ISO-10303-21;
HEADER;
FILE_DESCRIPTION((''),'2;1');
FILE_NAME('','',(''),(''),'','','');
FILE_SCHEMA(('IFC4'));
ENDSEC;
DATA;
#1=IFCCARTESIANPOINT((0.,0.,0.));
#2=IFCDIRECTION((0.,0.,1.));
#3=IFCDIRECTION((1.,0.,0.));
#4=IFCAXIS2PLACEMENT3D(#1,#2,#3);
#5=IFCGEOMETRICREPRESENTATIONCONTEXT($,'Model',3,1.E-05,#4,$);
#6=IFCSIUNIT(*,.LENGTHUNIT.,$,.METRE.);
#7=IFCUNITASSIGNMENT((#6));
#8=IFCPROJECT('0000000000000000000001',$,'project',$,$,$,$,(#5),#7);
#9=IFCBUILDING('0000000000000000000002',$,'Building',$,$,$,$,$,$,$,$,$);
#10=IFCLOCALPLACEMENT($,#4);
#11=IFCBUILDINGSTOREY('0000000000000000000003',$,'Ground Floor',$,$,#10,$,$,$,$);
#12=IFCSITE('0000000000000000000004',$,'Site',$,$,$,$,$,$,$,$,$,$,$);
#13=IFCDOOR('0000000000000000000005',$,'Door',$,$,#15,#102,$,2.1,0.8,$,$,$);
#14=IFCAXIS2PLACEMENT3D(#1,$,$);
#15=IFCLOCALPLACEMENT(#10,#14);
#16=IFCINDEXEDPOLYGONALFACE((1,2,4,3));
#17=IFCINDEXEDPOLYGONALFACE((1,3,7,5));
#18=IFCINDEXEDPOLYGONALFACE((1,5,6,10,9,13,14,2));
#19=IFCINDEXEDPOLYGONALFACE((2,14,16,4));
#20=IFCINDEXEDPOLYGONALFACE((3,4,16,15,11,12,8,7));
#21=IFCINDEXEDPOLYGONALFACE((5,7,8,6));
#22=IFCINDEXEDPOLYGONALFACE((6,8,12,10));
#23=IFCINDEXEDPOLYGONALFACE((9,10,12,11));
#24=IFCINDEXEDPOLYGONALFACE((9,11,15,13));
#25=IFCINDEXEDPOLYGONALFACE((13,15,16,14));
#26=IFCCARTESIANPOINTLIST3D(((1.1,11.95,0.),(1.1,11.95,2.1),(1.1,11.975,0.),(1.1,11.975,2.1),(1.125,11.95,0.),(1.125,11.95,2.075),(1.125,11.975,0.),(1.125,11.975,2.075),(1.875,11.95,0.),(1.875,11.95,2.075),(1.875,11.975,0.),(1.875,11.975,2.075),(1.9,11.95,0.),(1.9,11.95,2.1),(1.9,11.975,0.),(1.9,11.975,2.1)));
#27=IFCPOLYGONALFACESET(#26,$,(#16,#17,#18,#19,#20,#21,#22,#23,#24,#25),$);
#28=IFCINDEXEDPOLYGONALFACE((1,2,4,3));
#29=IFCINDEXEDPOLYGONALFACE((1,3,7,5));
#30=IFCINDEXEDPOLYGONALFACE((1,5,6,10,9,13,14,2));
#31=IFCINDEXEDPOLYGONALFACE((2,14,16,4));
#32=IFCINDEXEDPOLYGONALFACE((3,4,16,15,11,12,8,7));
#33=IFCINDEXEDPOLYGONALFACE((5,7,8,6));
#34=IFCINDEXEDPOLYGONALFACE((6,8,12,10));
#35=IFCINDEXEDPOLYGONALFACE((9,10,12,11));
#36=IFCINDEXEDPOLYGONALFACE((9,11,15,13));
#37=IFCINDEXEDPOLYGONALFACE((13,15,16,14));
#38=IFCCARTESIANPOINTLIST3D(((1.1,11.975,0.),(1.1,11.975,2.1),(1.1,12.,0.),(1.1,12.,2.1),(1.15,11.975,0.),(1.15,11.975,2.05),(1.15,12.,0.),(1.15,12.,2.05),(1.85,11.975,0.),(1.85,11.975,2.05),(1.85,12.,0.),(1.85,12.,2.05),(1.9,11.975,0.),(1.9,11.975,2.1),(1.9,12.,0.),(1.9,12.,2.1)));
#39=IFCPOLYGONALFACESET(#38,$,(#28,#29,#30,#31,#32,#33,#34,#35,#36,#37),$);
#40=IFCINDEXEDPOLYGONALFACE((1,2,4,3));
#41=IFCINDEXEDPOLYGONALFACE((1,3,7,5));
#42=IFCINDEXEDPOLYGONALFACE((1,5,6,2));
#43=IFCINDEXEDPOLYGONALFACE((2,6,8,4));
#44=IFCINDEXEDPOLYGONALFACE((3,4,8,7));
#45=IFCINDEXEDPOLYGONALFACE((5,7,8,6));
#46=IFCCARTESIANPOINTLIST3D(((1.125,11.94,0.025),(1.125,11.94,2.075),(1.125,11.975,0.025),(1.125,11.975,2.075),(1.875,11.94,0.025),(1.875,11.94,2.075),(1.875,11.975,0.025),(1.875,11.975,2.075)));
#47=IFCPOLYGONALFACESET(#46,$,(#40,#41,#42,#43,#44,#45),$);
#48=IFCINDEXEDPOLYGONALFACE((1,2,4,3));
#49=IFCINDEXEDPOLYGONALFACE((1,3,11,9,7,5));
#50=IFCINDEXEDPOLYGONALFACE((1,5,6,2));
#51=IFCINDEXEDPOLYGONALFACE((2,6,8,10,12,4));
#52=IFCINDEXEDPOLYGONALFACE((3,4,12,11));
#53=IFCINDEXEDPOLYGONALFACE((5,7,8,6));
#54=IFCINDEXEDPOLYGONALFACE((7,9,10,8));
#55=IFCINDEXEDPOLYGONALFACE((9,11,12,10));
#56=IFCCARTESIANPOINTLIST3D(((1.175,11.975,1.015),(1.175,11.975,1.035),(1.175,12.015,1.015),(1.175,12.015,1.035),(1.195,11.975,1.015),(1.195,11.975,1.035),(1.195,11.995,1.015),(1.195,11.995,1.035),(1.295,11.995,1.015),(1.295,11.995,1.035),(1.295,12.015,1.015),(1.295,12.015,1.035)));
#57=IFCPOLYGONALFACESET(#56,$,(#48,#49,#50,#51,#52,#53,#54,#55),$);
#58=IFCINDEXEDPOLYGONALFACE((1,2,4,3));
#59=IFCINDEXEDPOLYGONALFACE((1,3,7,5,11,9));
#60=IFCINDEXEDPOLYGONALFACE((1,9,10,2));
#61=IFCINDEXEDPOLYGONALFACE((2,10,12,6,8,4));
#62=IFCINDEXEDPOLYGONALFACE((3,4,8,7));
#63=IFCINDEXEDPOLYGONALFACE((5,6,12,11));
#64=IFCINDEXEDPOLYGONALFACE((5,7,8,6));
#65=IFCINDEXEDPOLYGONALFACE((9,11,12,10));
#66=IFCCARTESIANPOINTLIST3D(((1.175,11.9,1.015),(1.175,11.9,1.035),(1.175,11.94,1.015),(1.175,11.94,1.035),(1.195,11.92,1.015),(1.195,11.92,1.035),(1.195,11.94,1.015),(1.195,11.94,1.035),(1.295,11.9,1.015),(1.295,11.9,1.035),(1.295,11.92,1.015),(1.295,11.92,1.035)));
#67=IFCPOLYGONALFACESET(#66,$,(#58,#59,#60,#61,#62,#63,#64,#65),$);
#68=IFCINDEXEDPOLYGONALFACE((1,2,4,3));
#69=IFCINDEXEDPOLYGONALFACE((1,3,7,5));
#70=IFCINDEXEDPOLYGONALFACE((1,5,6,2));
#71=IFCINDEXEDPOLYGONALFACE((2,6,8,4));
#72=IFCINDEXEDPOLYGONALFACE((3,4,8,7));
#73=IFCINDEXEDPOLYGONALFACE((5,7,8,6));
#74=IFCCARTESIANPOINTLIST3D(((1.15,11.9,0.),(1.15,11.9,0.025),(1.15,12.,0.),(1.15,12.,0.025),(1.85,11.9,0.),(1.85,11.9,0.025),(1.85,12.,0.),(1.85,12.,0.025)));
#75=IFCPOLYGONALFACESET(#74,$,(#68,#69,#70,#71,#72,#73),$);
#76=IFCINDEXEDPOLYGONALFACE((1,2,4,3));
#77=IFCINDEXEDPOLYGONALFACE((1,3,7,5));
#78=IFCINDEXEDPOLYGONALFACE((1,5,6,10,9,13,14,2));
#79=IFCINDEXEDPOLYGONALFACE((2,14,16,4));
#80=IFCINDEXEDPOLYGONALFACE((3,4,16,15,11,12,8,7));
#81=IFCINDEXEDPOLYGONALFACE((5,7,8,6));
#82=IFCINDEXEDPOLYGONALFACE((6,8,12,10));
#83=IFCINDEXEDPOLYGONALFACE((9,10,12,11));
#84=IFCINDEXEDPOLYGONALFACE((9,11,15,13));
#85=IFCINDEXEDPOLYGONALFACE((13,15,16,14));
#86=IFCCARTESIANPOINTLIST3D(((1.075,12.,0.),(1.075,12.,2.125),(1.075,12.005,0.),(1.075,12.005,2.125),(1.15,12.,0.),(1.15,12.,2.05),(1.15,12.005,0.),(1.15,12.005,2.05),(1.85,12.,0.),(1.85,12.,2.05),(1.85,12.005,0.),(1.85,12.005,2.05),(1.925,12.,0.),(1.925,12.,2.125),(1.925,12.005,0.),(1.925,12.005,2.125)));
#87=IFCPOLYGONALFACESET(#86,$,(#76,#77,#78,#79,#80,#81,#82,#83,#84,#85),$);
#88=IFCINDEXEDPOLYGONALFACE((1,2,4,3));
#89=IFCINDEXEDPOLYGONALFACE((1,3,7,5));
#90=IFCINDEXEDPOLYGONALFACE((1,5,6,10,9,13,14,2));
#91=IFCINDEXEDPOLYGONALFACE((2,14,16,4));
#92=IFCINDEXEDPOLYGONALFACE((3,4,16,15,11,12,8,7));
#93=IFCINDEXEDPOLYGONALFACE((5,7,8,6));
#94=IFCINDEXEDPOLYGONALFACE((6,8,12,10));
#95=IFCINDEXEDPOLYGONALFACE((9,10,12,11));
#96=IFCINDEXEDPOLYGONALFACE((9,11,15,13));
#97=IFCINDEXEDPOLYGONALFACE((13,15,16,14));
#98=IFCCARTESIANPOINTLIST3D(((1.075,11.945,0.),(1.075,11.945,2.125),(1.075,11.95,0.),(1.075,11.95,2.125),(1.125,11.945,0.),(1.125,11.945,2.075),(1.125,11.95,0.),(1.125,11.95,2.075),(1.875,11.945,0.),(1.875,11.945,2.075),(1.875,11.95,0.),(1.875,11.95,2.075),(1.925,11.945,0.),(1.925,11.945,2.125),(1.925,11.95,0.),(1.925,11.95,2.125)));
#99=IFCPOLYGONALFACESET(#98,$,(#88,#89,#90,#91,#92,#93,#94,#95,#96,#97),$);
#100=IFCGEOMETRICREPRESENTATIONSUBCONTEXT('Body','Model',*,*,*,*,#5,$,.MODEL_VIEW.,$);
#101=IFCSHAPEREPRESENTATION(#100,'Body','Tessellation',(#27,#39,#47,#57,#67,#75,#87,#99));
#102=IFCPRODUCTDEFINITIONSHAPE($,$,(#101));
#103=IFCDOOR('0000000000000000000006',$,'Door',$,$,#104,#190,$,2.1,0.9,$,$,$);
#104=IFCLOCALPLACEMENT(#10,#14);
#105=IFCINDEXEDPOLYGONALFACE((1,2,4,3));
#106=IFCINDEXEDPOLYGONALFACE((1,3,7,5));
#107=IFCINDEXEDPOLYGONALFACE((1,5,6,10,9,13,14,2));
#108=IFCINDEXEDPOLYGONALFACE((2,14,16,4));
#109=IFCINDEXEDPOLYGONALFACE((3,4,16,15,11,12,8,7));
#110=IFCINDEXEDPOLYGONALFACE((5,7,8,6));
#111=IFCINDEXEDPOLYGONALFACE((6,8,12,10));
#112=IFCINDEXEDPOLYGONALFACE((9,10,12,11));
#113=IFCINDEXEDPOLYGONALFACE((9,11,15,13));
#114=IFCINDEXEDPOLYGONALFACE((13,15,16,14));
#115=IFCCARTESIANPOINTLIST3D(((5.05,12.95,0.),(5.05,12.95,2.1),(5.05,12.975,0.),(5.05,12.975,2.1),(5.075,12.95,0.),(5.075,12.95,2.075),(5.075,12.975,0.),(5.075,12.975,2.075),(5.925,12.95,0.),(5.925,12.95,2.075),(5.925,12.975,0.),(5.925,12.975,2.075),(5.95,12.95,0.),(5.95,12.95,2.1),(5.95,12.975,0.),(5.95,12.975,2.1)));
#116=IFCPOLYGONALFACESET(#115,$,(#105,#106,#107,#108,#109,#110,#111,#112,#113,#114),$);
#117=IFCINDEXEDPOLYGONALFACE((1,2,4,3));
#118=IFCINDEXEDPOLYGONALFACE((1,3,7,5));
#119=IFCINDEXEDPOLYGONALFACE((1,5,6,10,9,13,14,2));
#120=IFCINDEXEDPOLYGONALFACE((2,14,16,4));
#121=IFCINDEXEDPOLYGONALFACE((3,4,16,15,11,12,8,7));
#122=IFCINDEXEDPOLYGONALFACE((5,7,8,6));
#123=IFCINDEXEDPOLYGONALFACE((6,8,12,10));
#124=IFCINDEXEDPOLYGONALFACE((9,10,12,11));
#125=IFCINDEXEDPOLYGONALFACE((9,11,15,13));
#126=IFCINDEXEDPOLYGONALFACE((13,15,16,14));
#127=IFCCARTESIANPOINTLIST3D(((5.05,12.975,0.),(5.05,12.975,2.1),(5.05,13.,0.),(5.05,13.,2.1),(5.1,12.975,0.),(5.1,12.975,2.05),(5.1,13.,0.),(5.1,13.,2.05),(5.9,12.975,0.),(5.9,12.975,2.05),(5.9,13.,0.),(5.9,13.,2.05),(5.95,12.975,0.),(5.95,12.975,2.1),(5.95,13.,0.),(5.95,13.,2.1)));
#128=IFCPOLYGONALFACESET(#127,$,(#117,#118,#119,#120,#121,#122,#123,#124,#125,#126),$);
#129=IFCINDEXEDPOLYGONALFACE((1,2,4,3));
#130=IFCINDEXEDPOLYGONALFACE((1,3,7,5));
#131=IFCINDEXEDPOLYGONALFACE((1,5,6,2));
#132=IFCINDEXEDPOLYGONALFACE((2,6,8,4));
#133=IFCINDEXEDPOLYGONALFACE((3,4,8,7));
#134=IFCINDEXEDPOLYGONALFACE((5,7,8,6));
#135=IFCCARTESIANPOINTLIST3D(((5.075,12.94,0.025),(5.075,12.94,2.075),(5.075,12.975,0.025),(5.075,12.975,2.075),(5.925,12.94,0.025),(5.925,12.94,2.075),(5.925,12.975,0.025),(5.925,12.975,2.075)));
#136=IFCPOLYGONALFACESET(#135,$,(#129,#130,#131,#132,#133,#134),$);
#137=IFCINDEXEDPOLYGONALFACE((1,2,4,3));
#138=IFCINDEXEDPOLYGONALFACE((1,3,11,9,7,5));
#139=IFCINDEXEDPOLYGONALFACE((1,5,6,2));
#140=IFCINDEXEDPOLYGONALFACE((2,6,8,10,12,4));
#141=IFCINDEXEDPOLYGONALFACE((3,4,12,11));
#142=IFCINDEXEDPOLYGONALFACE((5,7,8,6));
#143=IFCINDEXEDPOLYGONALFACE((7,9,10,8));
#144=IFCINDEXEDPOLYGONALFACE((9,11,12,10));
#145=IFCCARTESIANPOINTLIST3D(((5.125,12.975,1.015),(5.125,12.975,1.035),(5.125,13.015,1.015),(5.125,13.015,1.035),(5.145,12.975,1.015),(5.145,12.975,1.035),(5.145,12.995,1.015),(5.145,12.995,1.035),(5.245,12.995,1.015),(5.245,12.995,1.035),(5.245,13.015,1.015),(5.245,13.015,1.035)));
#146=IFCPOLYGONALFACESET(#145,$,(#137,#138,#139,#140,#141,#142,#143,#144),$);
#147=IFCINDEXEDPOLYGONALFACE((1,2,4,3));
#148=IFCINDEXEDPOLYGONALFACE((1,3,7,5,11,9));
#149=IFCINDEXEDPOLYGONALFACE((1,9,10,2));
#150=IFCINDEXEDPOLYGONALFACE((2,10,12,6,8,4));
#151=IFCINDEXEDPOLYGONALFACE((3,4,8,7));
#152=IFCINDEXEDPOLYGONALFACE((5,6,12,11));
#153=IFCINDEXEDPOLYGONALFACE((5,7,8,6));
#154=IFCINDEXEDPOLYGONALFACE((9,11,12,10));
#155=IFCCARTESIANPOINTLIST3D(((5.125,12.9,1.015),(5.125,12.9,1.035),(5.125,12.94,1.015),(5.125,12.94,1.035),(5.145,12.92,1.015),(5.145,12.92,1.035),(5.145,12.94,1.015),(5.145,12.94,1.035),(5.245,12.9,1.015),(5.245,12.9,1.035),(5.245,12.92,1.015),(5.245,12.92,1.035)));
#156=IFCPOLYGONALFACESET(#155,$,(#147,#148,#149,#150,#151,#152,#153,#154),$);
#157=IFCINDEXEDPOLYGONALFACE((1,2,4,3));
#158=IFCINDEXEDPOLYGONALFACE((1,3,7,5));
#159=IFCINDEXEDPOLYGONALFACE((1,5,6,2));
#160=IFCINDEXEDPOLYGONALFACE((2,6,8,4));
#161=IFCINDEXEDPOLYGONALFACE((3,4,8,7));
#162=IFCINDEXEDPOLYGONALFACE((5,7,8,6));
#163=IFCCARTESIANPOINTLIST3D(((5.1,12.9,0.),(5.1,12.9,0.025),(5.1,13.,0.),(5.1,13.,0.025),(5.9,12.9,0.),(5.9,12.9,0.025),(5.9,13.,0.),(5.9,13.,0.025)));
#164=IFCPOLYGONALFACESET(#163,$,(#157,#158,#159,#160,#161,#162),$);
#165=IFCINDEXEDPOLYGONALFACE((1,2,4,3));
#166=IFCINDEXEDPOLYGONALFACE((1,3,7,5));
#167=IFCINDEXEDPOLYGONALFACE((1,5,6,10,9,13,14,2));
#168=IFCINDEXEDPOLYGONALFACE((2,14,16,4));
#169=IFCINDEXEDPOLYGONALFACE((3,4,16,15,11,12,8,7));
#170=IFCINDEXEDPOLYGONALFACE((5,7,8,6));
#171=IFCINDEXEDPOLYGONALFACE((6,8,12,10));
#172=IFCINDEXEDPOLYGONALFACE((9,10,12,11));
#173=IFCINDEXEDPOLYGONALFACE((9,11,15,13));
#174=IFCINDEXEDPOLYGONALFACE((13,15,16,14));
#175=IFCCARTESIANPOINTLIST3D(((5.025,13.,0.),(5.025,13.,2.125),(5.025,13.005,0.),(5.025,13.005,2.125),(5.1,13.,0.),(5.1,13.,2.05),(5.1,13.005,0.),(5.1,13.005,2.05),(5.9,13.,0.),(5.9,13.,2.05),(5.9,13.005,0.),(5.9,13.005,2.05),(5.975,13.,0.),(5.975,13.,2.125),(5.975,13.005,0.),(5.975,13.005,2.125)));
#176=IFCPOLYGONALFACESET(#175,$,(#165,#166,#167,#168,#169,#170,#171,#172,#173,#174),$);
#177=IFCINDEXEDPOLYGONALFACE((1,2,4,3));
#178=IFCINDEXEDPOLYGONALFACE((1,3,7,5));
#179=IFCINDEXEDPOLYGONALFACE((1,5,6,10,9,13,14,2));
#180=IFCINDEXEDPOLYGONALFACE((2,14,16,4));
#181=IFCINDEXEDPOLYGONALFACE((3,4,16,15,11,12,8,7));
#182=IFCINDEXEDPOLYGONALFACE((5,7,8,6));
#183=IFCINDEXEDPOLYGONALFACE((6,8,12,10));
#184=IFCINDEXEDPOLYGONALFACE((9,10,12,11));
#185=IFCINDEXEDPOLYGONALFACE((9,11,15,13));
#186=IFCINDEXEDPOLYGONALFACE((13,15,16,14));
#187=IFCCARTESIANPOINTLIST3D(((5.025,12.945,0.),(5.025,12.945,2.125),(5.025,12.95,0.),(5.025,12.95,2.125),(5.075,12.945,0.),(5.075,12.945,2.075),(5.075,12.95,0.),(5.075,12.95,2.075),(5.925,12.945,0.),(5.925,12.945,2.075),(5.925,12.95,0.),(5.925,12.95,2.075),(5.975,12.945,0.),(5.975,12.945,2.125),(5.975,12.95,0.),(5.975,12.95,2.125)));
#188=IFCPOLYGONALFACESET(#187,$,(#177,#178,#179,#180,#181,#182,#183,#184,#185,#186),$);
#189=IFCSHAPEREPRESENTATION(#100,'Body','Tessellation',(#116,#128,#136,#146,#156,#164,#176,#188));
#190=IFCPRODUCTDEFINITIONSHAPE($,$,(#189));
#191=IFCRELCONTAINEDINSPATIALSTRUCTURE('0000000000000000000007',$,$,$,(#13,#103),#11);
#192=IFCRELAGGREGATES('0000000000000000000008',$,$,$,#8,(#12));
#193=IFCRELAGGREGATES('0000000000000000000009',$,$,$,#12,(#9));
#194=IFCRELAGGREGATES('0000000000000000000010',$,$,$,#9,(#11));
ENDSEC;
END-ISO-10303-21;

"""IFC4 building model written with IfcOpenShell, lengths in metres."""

from ifc_helpers import new_model, si_unit, frame, origin_with_axes, place, context, subcontext, project, spatial, line, indexed_curve, outline, extrude, element, save


model = new_model("IFC4")

# Units and contexts
model_context = context("Model", 3, precision=1e-05, world=origin_with_axes())
body_context = subcontext(model_context, "Body", "Model", "MODEL_VIEW")
ifc_project = project(units=[si_unit("LENGTHUNIT", "METRE")], contexts=[model_context])

# Site, building, storey
site = spatial("IfcSite", under=ifc_project, Name="Site")
building = spatial("IfcBuilding", under=site, Name="Building")
storey_placement = place(None, origin_with_axes())
storey = spatial("IfcBuildingStorey", under=building, at=storey_placement, Name="Ground Floor")

# Doors
door_1_placement = place(storey_placement, frame((1.9, 12.0, 0.0), z_axis=(0.0, 0.0, 1.0), x_axis=(-1.0, 0.0, 0.0)))
element("IfcDoor", 1, at=door_1_placement, inside=storey, Name="Door", OverallHeight=2.1, OverallWidth=0.8, context=body_context, shape_type="SweptSolid", body=[
    extrude(outline(indexed_curve([(0.0, 0.0), (0.0, 2.1), (0.8, 2.1), (0.8, 0.0), (0.775, 0.0), (0.775, 2.075), (0.025, 2.075), (0.025, 0.0)], segments=[line(1, 2, 3, 4, 5, 6, 7, 8, 1)])), frame((0.0, 0.025, 0.0), z_axis=(0.0, -1.0, 0.0), x_axis=(1.0, 0.0, 0.0)), (0.0, 0.0, -1.0), 0.025),
    extrude(outline(indexed_curve([(0.0, 0.0), (0.0, 2.1), (0.8, 2.1), (0.8, 0.0), (0.75, 0.0), (0.75, 2.05), (0.05, 2.05), (0.05, 0.0)], segments=[line(1, 2, 3, 4, 5, 6, 7, 8, 1)])), frame((0.0, 0.0, 0.0), z_axis=(0.0, -1.0, 0.0), x_axis=(1.0, 0.0, 0.0)), (0.0, 0.0, -1.0), 0.025),
    extrude(outline(indexed_curve([(0.0, 0.0), (0.75, 0.0), (0.75, 0.035), (0.0, 0.035)], segments=[line(1, 2, 3, 4, 1)])), frame((0.025, 0.025, 0.025), z_axis=(0.0, 0.0, 1.0), x_axis=(1.0, 0.0, 0.0)), (0.0, 0.0, 1.0), 2.05),
    extrude(outline(indexed_curve([(0.0, 0.0), (0.0, -0.04), (-0.12, -0.04), (-0.12, -0.02), (-0.02, -0.02), (-0.02, 0.0)], segments=[line(1, 2, 3, 4, 5, 6, 1)])), frame((0.725, 0.025, 1.015), z_axis=(0.0, 0.0, 1.0), x_axis=(1.0, 0.0, 0.0)), (0.0, 0.0, 1.0), 0.02),
    extrude(outline(indexed_curve([(0.0, 0.0), (0.0, 0.04), (-0.12, 0.04), (-0.12, 0.02), (-0.02, 0.02), (-0.02, 0.0)], segments=[line(1, 2, 3, 4, 5, 6, 1)])), frame((0.725, 0.06, 1.015), z_axis=(0.0, 0.0, 1.0), x_axis=(1.0, 0.0, 0.0)), (0.0, 0.0, 1.0), 0.02),
    extrude(outline(indexed_curve([(0.0, 0.0), (0.7, 0.0), (0.7, 0.1), (0.0, 0.1)], segments=[line(1, 2, 3, 4, 1)])), frame((0.05, 0.0, 0.0), z_axis=(0.0, 0.0, 1.0), x_axis=(1.0, 0.0, 0.0)), (0.0, 0.0, 1.0), 0.025),
    extrude(outline(indexed_curve([(0.0, 0.0), (0.0, 2.125), (0.85, 2.125), (0.85, 0.0), (0.775, 0.0), (0.775, 2.05), (0.075, 2.05), (0.075, 0.0)], segments=[line(1, 2, 3, 4, 5, 6, 7, 8, 1)])), frame((-0.025, -0.005, 0.0), z_axis=(0.0, -1.0, 0.0), x_axis=(1.0, 0.0, 0.0)), (0.0, 0.0, -1.0), 0.005),
    extrude(outline(indexed_curve([(0.0, 0.0), (0.0, 2.125), (0.85, 2.125), (0.85, 0.0), (0.8, 0.0), (0.8, 2.075), (0.05, 2.075), (0.05, 0.0)], segments=[line(1, 2, 3, 4, 5, 6, 7, 8, 1)])), frame((-0.025, 0.05, 0.0), z_axis=(0.0, -1.0, 0.0), x_axis=(1.0, 0.0, 0.0)), (0.0, 0.0, -1.0), 0.005),
])
door_2_placement = place(storey_placement, frame((5.95, 13.0, 0.0), z_axis=(0.0, 0.0, 1.0), x_axis=(-1.0, 0.0, 0.0)))
element("IfcDoor", 2, at=door_2_placement, inside=storey, Name="Door", OverallHeight=2.1, OverallWidth=0.9, context=body_context, shape_type="SweptSolid", body=[
    extrude(outline(indexed_curve([(0.0, 0.0), (0.0, 2.1), (0.9, 2.1), (0.9, 0.0), (0.875, 0.0), (0.875, 2.075), (0.025, 2.075), (0.025, 0.0)], segments=[line(1, 2, 3, 4, 5, 6, 7, 8, 1)])), frame((0.0, 0.025, 0.0), z_axis=(0.0, -1.0, 0.0), x_axis=(1.0, 0.0, 0.0)), (0.0, 0.0, -1.0), 0.025),
    extrude(outline(indexed_curve([(0.0, 0.0), (0.0, 2.1), (0.9, 2.1), (0.9, 0.0), (0.85, 0.0), (0.85, 2.05), (0.05, 2.05), (0.05, 0.0)], segments=[line(1, 2, 3, 4, 5, 6, 7, 8, 1)])), frame((0.0, 0.0, 0.0), z_axis=(0.0, -1.0, 0.0), x_axis=(1.0, 0.0, 0.0)), (0.0, 0.0, -1.0), 0.025),
    extrude(outline(indexed_curve([(0.0, 0.0), (0.85, 0.0), (0.85, 0.035), (0.0, 0.035)], segments=[line(1, 2, 3, 4, 1)])), frame((0.025, 0.025, 0.025), z_axis=(0.0, 0.0, 1.0), x_axis=(1.0, 0.0, 0.0)), (0.0, 0.0, 1.0), 2.05),
    extrude(outline(indexed_curve([(0.0, 0.0), (0.0, -0.04), (-0.12, -0.04), (-0.12, -0.02), (-0.02, -0.02), (-0.02, 0.0)], segments=[line(1, 2, 3, 4, 5, 6, 1)])), frame((0.825, 0.025, 1.015), z_axis=(0.0, 0.0, 1.0), x_axis=(1.0, 0.0, 0.0)), (0.0, 0.0, 1.0), 0.02),
    extrude(outline(indexed_curve([(0.0, 0.0), (0.0, 0.04), (-0.12, 0.04), (-0.12, 0.02), (-0.02, 0.02), (-0.02, 0.0)], segments=[line(1, 2, 3, 4, 5, 6, 1)])), frame((0.825, 0.06, 1.015), z_axis=(0.0, 0.0, 1.0), x_axis=(1.0, 0.0, 0.0)), (0.0, 0.0, 1.0), 0.02),
    extrude(outline(indexed_curve([(0.0, 0.0), (0.8, 0.0), (0.8, 0.1), (0.0, 0.1)], segments=[line(1, 2, 3, 4, 1)])), frame((0.05, 0.0, 0.0), z_axis=(0.0, 0.0, 1.0), x_axis=(1.0, 0.0, 0.0)), (0.0, 0.0, 1.0), 0.025),
    extrude(outline(indexed_curve([(0.0, 0.0), (0.0, 2.125), (0.95, 2.125), (0.95, 0.0), (0.875, 0.0), (0.875, 2.05), (0.075, 2.05), (0.075, 0.0)], segments=[line(1, 2, 3, 4, 5, 6, 7, 8, 1)])), frame((-0.025, -0.005, 0.0), z_axis=(0.0, -1.0, 0.0), x_axis=(1.0, 0.0, 0.0)), (0.0, 0.0, -1.0), 0.005),
    extrude(outline(indexed_curve([(0.0, 0.0), (0.0, 2.125), (0.95, 2.125), (0.95, 0.0), (0.9, 0.0), (0.9, 2.075), (0.05, 2.075), (0.05, 0.0)], segments=[line(1, 2, 3, 4, 5, 6, 7, 8, 1)])), frame((-0.025, 0.05, 0.0), z_axis=(0.0, -1.0, 0.0), x_axis=(1.0, 0.0, 0.0)), (0.0, 0.0, -1.0), 0.005),
])

save(model, "model.ifc")
